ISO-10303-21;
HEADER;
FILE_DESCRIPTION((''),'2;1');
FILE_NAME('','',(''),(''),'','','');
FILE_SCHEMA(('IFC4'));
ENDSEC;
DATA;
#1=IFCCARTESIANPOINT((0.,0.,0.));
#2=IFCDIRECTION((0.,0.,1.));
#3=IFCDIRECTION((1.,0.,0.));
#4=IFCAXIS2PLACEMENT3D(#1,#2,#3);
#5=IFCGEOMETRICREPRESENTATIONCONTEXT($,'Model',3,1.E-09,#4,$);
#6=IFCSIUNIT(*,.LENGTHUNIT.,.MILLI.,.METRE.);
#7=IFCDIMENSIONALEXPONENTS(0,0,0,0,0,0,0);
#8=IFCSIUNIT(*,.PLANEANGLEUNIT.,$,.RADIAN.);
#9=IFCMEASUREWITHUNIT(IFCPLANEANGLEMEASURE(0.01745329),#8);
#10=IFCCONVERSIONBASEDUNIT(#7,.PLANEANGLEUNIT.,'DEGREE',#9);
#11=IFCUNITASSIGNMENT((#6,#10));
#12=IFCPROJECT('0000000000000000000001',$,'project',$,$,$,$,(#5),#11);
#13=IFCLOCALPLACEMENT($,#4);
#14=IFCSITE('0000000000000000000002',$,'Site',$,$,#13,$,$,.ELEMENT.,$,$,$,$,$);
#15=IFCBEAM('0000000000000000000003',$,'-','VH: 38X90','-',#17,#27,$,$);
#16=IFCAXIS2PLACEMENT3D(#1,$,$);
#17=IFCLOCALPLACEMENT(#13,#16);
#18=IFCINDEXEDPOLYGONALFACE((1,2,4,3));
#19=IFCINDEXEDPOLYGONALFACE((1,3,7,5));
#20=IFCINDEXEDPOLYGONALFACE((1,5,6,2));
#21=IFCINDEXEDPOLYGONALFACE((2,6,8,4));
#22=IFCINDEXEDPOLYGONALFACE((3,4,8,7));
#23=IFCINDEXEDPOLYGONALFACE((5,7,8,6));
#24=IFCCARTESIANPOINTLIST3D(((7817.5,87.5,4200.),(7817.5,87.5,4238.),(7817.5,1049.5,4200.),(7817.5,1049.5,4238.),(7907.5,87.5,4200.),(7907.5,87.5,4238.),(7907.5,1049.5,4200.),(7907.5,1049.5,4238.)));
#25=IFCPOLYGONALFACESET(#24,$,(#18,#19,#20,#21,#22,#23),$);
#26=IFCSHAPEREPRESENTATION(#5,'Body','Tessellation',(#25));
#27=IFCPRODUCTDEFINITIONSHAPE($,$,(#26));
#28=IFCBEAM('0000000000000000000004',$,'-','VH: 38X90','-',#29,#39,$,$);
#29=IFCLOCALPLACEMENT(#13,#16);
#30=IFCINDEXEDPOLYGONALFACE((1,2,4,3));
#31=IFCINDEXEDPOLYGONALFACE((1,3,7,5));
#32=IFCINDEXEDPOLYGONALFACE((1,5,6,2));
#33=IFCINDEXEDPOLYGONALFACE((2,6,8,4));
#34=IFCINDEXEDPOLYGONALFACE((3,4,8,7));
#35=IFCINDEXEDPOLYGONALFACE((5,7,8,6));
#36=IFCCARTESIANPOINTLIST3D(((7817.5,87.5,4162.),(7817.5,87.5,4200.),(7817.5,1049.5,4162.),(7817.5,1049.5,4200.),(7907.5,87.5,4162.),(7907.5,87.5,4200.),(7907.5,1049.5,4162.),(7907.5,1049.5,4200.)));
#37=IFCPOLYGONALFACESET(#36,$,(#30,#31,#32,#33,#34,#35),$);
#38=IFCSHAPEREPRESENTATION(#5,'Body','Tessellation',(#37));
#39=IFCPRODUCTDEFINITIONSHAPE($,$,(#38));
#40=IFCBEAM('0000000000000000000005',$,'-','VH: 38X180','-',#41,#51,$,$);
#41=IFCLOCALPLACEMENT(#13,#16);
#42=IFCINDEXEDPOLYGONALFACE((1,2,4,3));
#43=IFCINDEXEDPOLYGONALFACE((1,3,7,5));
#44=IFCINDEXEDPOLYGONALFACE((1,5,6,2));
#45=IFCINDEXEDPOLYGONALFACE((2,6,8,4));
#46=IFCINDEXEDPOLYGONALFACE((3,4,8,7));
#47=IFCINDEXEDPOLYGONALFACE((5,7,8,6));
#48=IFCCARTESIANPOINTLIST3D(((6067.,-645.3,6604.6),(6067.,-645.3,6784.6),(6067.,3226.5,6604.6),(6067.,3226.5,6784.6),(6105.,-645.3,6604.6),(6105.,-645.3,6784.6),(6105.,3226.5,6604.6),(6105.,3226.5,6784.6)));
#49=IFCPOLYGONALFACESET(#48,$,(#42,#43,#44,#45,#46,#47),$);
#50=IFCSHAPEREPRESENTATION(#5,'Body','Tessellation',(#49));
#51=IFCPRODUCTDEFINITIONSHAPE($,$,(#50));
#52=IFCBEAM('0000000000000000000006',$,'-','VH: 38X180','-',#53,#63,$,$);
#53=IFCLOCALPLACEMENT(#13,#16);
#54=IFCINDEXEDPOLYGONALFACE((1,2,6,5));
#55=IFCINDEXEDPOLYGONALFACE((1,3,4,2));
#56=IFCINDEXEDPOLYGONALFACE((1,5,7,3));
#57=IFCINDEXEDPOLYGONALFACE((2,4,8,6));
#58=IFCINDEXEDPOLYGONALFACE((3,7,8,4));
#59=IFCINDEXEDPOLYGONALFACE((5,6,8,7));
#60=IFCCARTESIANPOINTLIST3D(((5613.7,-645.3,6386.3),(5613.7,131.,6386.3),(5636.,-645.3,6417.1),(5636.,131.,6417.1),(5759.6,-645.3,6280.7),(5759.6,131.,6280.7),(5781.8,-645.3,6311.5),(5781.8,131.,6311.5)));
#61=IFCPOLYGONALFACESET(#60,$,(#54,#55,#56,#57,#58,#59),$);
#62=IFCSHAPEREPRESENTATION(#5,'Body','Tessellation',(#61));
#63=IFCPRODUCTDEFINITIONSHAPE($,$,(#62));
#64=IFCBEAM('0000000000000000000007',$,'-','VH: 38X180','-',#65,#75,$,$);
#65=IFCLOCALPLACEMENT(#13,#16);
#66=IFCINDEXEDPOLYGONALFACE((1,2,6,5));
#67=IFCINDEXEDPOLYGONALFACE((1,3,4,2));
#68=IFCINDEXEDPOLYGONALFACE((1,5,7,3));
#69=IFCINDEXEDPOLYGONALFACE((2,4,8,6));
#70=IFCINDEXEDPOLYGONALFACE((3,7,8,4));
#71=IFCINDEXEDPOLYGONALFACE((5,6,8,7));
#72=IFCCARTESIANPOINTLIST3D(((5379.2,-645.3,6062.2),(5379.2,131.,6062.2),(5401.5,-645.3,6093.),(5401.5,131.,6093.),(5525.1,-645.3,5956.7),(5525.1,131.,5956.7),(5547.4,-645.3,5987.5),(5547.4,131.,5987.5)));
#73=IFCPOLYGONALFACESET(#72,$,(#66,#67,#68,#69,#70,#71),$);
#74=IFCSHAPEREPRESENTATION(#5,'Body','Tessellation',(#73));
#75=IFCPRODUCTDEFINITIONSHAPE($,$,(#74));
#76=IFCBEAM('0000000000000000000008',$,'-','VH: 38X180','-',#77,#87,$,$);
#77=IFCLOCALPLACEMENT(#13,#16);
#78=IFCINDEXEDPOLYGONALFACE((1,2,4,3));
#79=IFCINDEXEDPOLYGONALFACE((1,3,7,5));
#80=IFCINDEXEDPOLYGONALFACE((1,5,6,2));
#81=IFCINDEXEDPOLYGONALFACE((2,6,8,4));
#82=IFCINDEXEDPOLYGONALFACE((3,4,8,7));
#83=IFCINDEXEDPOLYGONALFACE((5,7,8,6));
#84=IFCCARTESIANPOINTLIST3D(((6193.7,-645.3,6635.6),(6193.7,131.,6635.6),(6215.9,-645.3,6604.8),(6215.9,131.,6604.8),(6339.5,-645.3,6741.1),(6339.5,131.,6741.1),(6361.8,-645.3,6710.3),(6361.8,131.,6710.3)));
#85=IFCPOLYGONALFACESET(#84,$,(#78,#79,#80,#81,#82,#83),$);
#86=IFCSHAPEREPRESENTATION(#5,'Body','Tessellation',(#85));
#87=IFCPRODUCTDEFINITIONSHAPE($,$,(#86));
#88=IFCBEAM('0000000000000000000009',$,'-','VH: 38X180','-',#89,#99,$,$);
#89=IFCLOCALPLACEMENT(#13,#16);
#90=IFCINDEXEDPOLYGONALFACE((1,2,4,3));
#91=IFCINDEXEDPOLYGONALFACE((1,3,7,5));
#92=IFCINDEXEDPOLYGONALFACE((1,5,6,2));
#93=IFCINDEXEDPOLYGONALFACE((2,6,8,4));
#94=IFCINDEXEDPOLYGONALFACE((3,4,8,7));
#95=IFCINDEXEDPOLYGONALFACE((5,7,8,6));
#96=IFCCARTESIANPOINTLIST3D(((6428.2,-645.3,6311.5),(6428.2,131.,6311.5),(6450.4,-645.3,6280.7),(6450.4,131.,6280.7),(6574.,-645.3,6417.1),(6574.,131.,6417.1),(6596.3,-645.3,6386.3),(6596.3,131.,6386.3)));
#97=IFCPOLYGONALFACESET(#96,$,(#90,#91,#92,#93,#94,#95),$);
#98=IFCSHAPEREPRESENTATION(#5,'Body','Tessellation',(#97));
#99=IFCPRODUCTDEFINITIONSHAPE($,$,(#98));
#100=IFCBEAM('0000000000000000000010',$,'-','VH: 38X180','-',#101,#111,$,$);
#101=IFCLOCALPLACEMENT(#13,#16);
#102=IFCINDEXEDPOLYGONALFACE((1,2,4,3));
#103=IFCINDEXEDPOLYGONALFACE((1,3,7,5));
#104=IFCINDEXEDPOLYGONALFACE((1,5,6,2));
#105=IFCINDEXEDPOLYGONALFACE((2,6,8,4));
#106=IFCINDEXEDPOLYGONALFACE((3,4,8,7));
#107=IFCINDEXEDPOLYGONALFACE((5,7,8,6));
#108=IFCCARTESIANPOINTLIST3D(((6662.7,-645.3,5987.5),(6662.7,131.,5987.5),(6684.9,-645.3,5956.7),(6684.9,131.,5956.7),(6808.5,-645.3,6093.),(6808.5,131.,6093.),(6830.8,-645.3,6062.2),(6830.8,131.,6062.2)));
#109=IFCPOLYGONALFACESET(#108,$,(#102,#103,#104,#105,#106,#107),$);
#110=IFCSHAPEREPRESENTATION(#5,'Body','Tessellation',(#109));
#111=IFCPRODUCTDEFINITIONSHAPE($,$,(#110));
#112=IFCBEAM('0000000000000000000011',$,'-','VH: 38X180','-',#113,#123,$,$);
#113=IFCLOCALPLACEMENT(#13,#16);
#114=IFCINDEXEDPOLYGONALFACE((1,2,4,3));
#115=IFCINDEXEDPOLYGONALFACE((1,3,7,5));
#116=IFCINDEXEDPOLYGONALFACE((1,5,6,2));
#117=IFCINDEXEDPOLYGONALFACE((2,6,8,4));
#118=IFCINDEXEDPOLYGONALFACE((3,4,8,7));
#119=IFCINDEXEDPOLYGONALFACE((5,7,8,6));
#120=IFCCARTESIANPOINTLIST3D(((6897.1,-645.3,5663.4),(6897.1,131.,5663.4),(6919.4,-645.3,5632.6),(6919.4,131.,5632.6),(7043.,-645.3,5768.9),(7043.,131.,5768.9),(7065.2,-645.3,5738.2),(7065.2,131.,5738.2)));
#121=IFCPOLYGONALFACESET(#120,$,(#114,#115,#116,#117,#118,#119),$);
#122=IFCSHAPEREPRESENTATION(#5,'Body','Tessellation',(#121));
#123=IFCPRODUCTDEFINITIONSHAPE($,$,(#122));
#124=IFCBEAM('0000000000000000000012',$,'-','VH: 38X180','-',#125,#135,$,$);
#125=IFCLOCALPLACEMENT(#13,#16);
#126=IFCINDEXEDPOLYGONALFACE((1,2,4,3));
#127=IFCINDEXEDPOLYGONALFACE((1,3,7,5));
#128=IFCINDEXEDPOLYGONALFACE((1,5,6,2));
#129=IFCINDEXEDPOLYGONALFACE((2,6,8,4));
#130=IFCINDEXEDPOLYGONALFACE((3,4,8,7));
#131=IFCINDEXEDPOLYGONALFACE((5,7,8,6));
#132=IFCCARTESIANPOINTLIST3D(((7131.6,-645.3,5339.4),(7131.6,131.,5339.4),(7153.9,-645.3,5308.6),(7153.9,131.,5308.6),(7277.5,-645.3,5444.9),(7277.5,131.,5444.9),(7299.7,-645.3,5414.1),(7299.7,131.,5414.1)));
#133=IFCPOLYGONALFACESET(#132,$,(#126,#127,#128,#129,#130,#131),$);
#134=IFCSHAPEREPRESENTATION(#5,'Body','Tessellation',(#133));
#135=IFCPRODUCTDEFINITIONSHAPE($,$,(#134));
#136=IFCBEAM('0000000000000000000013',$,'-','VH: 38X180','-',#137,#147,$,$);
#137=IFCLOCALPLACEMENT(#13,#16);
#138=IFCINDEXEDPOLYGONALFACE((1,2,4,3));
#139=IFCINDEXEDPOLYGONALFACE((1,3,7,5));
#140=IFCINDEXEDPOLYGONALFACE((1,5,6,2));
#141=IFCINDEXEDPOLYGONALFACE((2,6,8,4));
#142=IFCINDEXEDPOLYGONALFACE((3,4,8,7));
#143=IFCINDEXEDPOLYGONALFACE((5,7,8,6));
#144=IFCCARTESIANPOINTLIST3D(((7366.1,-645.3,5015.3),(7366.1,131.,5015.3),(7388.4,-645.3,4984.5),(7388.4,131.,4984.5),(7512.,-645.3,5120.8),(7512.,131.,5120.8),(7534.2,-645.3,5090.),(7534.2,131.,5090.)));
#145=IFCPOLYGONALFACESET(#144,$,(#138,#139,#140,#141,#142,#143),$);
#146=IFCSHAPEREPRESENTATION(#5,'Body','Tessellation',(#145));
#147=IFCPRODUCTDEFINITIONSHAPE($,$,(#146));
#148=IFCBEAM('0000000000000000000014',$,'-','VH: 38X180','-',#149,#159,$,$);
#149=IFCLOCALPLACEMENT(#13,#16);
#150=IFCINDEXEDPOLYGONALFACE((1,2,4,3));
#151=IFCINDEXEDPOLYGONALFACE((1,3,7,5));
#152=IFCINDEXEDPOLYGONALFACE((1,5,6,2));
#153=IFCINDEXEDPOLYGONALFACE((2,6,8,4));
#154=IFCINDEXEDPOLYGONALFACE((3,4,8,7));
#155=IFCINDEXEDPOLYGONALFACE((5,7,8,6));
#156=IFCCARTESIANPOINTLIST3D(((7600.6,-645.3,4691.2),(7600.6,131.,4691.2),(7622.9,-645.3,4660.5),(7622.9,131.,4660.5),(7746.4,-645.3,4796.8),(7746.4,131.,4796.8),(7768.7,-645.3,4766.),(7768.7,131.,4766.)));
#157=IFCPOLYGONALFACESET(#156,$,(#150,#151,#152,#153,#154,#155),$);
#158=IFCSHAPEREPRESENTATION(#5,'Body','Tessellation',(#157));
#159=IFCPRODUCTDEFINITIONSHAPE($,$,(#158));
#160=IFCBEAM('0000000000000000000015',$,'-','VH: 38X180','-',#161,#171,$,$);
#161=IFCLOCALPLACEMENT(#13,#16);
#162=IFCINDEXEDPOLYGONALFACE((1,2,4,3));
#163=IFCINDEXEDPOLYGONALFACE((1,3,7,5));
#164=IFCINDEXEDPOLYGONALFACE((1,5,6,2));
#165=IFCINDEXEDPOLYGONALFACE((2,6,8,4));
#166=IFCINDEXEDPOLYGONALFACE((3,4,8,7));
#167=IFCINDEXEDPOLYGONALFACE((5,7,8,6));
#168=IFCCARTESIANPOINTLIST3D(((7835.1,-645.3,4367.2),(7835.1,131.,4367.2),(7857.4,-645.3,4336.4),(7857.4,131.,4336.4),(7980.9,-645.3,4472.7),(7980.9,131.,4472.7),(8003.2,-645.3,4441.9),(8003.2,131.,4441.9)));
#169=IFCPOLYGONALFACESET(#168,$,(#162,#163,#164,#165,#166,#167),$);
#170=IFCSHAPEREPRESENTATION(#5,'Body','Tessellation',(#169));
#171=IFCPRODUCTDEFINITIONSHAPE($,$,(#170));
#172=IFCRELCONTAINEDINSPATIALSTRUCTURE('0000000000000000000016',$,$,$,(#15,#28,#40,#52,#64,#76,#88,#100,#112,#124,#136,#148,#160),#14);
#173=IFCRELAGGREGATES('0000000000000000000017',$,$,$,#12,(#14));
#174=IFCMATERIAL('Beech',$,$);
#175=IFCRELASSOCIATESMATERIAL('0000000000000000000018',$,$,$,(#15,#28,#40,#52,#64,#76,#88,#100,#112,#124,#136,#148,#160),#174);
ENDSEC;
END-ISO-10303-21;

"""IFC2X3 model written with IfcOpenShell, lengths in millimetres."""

from ifc_helpers import new_model, entity, si_unit, converted_unit, frame, origin, origin_with_axes, origin_2d, place, context, project, spatial, rectangle, extrude, material, element, save


model = new_model("IFC2X3")

# Units and contexts
model_context = context("Model", 3, precision=1e-09, world=origin_with_axes())
ifc_project = project(units=[si_unit("LENGTHUNIT", "METRE", prefix="MILLI"), converted_unit("PLANEANGLEUNIT", "DEGREE", entity("IfcPlaneAngleMeasure", 0.01745329), si_unit("PLANEANGLEUNIT", "RADIAN"), dimensions=[0, 0, 0, 0, 0, 0, 0])], contexts=[model_context])

# Site
site_placement = place(None, origin_with_axes())
site = spatial("IfcSite", under=ifc_project, at=site_placement, Name="Site", CompositionType="ELEMENT")

# Beams
ifc_material = material(Name="Beech")
for number, where, z_axis, x_axis, name in (
    (1, (7862.5, 87.5, 4219.0), (0.0, -1.0, 0.0), (0.0, 0.0, 1.0), "-"),
    (2, (7862.5, 87.5, 4181.0), (0.0, -1.0, 0.0), (0.0, 0.0, 1.0), "-"),
):
    element("IfcBeam", number, at=place(None, frame(where, z_axis=z_axis, x_axis=x_axis)), inside=site, material=ifc_material, Name=name, Description="VH: 38X90", ObjectType="-", context=model_context, shape_type="SweptSolid", body=[
        extrude(rectangle(XDim=38.0, YDim=90.0, at=origin_2d()), origin(), (0.0, 0.0, -1.0), 962.0),
    ])

# Beam
beam_placement = place(None, frame((6086.0, -645.3, 6694.6), z_axis=(0.0, -1.0, 0.0), x_axis=(-1.0, 0.0, 0.0)))
element("IfcBeam", 3, at=beam_placement, inside=site, material=ifc_material, Name="-", Description="VH: 38X180", ObjectType="-", context=model_context, shape_type="SweptSolid", body=[
    extrude(rectangle(XDim=38.0, YDim=180.0, at=origin_2d()), origin(), (0.0, 0.0, -1.0), 3871.8),
])

# Beams
for number, where, z_axis, x_axis, name in (
    (4, (5697.8, 131.0, 6348.9), (0.0, 1.0, 0.0), (0.58623, 0.0, 0.810145), "-"),
    (5, (5463.3, 131.0, 6024.8), (0.0, 1.0, 0.0), (0.58623, 0.0, 0.810145), "-"),
):
    element("IfcBeam", number, at=place(None, frame(where, z_axis=z_axis, x_axis=x_axis)), inside=site, material=ifc_material, Name=name, Description="VH: 38X180", ObjectType="-", context=model_context, shape_type="SweptSolid", body=[
        extrude(rectangle(XDim=38.0, YDim=180.0, at=origin_2d()), origin(), (0.0, 0.0, -1.0), 776.3),
    ])
for number, where, z_axis, x_axis, name in (
    (6, (6277.7, 131.0, 6673.0), (0.0, -1.0, 0.0), (-0.58623, 0.0, 0.810145), "-"),
    (7, (6512.2, 131.0, 6348.9), (0.0, -1.0, 0.0), (-0.58623, 0.0, 0.810145), "-"),
    (8, (6746.7, 131.0, 6024.8), (0.0, -1.0, 0.0), (-0.58623, 0.0, 0.810145), "-"),
    (9, (6981.2, 131.0, 5700.8), (0.0, -1.0, 0.0), (-0.58623, 0.0, 0.810145), "-"),
    (10, (7215.7, 131.0, 5376.7), (0.0, -1.0, 0.0), (-0.58623, 0.0, 0.810145), "-"),
    (11, (7450.2, 131.0, 5052.7), (0.0, -1.0, 0.0), (-0.58623, 0.0, 0.810145), "-"),
    (12, (7684.7, 131.0, 4728.6), (0.0, -1.0, 0.0), (-0.58623, 0.0, 0.810145), "-"),
    (13, (7919.2, 131.0, 4404.6), (0.0, -1.0, 0.0), (-0.58623, 0.0, 0.810145), "-"),
):
    element("IfcBeam", number, at=place(None, frame(where, z_axis=z_axis, x_axis=x_axis)), inside=site, material=ifc_material, Name=name, Description="VH: 38X180", ObjectType="-", context=model_context, shape_type="SweptSolid", body=[
        extrude(rectangle(XDim=38.0, YDim=180.0, at=origin_2d()), origin(), (0.0, 0.0, 1.0), 776.3),
    ])

save(model, "model.ifc")
